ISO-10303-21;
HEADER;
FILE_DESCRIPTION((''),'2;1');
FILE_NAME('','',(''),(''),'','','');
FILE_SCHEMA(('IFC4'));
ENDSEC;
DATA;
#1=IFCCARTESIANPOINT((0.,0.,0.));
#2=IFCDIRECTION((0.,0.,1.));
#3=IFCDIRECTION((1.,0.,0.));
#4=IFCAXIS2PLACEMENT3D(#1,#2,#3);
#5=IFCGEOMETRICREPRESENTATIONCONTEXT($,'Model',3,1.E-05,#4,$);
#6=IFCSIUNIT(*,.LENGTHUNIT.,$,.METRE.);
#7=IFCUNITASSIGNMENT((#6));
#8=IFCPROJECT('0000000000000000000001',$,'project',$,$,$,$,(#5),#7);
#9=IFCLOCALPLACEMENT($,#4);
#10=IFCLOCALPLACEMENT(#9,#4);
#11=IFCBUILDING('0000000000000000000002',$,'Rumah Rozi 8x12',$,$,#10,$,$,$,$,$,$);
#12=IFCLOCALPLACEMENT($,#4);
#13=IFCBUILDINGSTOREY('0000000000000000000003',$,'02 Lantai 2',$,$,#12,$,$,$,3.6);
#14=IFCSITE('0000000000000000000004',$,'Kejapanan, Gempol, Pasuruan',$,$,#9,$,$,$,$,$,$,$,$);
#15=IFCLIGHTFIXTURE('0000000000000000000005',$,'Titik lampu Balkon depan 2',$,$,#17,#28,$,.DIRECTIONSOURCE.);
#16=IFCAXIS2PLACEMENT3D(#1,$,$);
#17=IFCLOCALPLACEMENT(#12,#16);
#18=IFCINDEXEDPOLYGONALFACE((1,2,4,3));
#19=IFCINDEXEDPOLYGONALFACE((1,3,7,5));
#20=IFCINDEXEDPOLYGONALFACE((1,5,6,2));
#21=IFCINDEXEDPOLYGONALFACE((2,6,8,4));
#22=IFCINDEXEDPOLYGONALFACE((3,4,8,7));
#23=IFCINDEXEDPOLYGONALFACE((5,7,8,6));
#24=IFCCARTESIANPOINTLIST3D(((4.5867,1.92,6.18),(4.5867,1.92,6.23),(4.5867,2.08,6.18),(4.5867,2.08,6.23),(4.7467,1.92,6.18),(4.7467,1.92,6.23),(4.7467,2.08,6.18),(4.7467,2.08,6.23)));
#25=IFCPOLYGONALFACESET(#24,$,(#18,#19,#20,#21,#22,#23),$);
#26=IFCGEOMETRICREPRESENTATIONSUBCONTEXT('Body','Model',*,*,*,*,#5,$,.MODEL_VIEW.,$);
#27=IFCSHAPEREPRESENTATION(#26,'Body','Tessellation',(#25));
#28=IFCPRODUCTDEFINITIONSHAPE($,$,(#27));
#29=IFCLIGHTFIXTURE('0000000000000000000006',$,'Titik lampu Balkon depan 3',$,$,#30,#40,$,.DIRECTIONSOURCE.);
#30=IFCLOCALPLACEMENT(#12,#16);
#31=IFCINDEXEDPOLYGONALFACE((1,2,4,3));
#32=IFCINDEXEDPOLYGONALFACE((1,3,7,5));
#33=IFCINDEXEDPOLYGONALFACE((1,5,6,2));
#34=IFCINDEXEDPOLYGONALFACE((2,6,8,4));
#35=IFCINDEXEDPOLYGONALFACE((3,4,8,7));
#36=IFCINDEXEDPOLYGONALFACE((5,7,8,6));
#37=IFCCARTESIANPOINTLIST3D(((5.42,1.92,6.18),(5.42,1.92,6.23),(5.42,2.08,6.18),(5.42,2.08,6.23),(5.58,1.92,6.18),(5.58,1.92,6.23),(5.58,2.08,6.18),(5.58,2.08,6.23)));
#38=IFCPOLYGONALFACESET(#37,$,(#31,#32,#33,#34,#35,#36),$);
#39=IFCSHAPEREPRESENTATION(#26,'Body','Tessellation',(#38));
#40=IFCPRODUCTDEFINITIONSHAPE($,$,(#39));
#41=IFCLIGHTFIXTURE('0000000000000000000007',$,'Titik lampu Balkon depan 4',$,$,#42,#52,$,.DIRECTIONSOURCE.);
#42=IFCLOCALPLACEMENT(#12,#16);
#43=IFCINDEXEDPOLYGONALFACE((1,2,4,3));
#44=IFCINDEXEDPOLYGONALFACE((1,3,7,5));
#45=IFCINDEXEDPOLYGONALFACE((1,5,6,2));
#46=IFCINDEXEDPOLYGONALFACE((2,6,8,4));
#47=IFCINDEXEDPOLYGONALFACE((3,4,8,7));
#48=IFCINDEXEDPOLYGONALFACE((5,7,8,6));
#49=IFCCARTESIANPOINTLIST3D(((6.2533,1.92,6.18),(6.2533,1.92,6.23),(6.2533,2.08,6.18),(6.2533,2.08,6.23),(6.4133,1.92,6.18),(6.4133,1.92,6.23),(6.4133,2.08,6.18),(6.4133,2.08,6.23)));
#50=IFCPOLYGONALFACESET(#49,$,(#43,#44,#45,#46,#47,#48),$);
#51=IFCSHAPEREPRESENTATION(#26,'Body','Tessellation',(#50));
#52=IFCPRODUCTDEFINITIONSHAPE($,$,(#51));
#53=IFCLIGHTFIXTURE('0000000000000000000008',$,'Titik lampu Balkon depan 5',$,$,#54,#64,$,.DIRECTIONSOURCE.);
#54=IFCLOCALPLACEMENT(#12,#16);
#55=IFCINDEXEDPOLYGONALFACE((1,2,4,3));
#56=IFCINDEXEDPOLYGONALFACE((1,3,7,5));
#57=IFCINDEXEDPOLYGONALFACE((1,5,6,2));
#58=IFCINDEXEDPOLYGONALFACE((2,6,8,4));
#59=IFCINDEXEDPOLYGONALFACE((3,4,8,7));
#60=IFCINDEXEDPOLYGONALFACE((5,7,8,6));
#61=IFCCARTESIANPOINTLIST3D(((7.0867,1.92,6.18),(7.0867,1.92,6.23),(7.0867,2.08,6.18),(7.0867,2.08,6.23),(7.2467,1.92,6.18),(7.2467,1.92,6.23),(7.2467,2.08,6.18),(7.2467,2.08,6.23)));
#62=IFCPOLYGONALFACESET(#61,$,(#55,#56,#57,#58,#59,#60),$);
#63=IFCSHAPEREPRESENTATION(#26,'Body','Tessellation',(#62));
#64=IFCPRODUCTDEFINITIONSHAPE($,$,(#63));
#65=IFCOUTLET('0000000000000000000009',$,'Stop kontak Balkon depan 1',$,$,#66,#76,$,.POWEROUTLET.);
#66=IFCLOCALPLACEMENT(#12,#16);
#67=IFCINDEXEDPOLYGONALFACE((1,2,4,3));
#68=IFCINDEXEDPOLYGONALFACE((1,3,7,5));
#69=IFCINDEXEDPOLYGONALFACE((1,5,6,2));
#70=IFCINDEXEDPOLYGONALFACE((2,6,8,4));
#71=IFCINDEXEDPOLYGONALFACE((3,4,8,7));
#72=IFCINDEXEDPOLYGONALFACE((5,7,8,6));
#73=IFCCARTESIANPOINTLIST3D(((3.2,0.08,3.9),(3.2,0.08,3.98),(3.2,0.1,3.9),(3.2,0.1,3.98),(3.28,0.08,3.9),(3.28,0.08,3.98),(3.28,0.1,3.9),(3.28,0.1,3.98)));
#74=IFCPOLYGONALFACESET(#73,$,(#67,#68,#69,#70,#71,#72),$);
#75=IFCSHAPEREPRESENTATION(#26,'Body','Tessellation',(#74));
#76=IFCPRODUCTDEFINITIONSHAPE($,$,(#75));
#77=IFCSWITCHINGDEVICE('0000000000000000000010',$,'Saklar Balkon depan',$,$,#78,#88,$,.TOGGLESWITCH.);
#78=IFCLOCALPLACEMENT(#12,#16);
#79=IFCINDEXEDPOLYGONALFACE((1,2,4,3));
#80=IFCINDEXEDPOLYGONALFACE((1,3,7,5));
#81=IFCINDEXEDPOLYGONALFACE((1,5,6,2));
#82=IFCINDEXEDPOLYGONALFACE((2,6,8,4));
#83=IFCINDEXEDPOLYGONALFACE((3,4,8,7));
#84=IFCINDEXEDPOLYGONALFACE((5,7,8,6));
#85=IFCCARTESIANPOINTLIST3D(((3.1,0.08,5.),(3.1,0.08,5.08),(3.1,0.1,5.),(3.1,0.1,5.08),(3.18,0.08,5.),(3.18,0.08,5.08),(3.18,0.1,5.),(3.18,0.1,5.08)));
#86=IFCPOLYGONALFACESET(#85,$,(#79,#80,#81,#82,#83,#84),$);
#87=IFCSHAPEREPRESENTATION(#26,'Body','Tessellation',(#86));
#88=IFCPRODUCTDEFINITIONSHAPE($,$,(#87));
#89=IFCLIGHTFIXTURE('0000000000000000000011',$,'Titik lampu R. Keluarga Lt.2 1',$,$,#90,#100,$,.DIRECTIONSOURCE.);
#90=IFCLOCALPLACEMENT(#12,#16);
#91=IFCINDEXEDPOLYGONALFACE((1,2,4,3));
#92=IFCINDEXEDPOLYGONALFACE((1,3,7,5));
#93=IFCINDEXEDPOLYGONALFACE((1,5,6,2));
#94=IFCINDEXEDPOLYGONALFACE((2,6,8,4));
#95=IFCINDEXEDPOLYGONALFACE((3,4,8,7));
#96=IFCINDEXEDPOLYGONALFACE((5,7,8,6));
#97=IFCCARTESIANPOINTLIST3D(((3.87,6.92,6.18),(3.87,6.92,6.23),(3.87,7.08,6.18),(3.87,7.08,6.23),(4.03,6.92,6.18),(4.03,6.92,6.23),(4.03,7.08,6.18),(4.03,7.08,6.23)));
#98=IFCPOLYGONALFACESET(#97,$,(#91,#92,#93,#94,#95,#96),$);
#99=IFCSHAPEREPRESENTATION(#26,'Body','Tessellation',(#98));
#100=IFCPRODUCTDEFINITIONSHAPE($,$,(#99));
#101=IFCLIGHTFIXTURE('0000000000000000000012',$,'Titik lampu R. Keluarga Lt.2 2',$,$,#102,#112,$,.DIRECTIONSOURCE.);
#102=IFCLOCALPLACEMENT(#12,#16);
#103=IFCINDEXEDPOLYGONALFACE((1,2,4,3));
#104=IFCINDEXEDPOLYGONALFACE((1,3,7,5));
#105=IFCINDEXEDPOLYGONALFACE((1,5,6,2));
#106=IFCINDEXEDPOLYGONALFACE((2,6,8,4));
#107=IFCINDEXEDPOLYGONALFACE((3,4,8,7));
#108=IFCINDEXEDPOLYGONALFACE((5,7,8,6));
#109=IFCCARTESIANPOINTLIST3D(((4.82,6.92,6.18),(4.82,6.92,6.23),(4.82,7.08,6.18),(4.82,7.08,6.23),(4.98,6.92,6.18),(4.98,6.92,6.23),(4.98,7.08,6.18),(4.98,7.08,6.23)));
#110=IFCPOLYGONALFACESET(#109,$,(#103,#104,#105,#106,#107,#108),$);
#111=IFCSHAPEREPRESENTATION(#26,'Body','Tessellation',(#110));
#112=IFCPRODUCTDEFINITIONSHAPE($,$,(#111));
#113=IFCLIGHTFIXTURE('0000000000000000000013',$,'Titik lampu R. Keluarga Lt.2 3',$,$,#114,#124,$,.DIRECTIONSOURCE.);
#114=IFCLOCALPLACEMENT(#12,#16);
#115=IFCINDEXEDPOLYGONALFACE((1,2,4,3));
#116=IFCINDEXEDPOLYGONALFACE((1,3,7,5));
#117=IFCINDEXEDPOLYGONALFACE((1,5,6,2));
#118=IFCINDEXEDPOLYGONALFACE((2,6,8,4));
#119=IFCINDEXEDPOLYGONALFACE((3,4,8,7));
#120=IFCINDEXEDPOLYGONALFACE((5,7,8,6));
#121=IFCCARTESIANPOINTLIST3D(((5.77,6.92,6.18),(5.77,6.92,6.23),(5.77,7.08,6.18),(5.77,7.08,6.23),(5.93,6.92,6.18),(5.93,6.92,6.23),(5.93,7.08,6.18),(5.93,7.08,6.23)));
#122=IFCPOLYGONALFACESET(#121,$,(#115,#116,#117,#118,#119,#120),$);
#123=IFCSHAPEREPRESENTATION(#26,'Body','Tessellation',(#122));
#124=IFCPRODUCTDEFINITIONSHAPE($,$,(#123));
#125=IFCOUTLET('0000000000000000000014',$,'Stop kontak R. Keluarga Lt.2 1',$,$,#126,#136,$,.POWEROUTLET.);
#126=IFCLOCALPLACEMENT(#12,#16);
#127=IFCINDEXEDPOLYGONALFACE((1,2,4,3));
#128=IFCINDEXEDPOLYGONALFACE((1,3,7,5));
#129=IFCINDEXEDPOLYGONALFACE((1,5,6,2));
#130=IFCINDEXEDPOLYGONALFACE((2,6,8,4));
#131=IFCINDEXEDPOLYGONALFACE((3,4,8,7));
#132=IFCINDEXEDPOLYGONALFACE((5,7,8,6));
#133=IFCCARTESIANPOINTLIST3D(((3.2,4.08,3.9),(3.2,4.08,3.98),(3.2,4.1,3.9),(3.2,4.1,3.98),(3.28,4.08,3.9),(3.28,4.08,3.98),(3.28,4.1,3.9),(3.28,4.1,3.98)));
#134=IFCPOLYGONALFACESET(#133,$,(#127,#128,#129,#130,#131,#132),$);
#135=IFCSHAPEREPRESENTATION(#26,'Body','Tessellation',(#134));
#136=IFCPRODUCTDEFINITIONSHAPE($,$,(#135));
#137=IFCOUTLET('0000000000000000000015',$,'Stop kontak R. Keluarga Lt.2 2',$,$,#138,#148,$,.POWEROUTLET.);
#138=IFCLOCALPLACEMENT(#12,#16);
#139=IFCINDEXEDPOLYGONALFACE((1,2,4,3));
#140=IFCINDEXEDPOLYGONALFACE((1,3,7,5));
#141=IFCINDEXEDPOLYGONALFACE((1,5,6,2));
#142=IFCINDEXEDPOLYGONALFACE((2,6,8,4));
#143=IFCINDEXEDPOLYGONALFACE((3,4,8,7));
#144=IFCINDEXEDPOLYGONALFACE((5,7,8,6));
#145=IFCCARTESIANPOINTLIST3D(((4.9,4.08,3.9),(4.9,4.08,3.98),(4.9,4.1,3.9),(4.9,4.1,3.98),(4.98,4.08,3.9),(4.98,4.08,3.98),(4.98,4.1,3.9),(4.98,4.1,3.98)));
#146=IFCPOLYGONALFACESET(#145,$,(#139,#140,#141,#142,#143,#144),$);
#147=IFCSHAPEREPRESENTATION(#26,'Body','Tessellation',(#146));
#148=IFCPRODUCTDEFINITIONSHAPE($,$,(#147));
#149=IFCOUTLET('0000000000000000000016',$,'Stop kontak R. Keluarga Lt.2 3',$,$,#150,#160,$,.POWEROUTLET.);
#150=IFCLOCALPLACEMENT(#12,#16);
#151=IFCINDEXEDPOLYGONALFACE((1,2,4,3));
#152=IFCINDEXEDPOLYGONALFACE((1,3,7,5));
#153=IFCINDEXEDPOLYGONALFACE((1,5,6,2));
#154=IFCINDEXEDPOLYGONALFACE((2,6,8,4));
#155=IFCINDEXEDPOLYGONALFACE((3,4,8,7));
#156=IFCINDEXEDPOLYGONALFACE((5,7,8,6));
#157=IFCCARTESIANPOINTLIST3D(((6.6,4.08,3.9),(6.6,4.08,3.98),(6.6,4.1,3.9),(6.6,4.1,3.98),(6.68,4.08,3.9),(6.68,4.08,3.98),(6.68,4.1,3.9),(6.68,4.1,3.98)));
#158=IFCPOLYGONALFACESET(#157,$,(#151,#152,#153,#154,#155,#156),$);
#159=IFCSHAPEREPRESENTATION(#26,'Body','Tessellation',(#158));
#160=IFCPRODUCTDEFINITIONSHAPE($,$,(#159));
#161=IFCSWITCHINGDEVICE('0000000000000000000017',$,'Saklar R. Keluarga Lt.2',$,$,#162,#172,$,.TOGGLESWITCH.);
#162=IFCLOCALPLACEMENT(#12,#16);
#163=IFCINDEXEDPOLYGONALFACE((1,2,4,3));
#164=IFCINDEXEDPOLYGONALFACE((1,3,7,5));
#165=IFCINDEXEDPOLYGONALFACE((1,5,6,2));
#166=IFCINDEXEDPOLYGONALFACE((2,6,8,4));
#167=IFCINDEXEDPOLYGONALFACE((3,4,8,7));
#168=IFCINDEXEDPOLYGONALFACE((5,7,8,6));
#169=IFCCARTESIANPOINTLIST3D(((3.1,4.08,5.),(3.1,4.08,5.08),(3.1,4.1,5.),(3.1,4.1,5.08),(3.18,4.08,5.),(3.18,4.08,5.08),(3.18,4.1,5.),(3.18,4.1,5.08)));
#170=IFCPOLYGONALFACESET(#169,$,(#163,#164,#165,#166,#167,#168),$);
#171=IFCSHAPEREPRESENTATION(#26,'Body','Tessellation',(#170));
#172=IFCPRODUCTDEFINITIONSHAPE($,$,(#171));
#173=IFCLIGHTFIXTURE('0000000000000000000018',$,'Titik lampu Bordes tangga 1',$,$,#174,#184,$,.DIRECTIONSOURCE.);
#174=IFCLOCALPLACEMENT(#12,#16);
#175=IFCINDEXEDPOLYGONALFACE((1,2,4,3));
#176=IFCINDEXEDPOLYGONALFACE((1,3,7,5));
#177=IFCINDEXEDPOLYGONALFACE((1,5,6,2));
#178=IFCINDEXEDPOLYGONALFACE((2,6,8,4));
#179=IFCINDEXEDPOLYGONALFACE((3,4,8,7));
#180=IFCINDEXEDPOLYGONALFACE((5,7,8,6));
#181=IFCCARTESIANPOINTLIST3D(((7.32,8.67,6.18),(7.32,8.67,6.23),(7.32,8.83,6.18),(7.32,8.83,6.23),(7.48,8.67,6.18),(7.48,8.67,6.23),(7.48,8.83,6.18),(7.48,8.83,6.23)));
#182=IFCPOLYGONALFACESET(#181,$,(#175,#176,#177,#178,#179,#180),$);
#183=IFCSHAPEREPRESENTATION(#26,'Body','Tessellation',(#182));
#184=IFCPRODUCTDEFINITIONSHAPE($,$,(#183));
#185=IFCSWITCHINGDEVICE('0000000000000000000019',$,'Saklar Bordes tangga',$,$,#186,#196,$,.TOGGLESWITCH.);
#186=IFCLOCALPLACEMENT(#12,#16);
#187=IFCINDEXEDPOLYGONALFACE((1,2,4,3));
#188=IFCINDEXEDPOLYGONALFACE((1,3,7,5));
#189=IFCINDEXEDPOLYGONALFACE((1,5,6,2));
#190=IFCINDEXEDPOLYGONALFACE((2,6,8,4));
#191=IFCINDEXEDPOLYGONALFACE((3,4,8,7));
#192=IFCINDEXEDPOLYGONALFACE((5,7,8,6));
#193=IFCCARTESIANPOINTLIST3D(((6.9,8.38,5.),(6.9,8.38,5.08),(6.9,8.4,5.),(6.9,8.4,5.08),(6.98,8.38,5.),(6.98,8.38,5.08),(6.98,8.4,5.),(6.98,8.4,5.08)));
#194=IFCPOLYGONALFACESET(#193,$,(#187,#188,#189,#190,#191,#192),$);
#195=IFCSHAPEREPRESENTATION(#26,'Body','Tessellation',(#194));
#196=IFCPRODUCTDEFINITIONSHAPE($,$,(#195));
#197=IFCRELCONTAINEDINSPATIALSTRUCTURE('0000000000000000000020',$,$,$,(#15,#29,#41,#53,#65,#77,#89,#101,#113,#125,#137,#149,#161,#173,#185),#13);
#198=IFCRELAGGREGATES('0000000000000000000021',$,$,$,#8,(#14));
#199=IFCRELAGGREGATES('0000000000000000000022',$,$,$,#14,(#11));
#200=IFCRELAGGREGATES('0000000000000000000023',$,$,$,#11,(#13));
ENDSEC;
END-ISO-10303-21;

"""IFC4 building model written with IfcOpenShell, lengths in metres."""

from ifc_helpers import new_model, si_unit, frame, origin_with_axes, place, context, subcontext, project, spatial, line, indexed_curve, outline, extrude, element, save


model = new_model("IFC4")

# Units and contexts
model_context = context("Model", 3, precision=1e-05, world=origin_with_axes())
body_context = subcontext(model_context, "Body", "Model", "MODEL_VIEW")
ifc_project = project(units=[si_unit("LENGTHUNIT", "METRE")], contexts=[model_context])

# Site, building, storey
site_placement = place(None, origin_with_axes())
site = spatial("IfcSite", under=ifc_project, at=site_placement, Name="Kejapanan, Gempol, Pasuruan")
building_placement = place(site_placement, origin_with_axes())
building = spatial("IfcBuilding", under=site, at=building_placement, Name="Rumah Rozi 8x12")
storey_placement = place(None, origin_with_axes())
storey = spatial("IfcBuildingStorey", under=building, at=storey_placement, Name="02 Lantai 2", Elevation=3.6)

# Light fixtures
light_fixture_1_placement = place(storey_placement, origin_with_axes())
element("IfcLightFixture", 1, at=light_fixture_1_placement, inside=storey, Name="Titik lampu Balkon depan 2", PredefinedType="DIRECTIONSOURCE", context=body_context, shape_type="SweptSolid", body=[
    extrude(outline(indexed_curve([(4.5867, 1.92), (4.7467, 1.92), (4.7467, 2.08), (4.5867, 2.08)], segments=[line(1, 2, 3, 4, 1)])), frame((0.0, 0.0, 6.18), z_axis=(0.0, 0.0, 1.0), x_axis=(1.0, 0.0, 0.0)), (0.0, 0.0, 1.0), 0.05),
])
light_fixture_2_placement = place(storey_placement, origin_with_axes())
element("IfcLightFixture", 2, at=light_fixture_2_placement, inside=storey, Name="Titik lampu Balkon depan 3", PredefinedType="DIRECTIONSOURCE", context=body_context, shape_type="SweptSolid", body=[
    extrude(outline(indexed_curve([(5.42, 1.92), (5.58, 1.92), (5.58, 2.08), (5.42, 2.08)], segments=[line(1, 2, 3, 4, 1)])), frame((0.0, 0.0, 6.18), z_axis=(0.0, 0.0, 1.0), x_axis=(1.0, 0.0, 0.0)), (0.0, 0.0, 1.0), 0.05),
])
light_fixture_3_placement = place(storey_placement, origin_with_axes())
element("IfcLightFixture", 3, at=light_fixture_3_placement, inside=storey, Name="Titik lampu Balkon depan 4", PredefinedType="DIRECTIONSOURCE", context=body_context, shape_type="SweptSolid", body=[
    extrude(outline(indexed_curve([(6.2533, 1.92), (6.4133, 1.92), (6.4133, 2.08), (6.2533, 2.08)], segments=[line(1, 2, 3, 4, 1)])), frame((0.0, 0.0, 6.18), z_axis=(0.0, 0.0, 1.0), x_axis=(1.0, 0.0, 0.0)), (0.0, 0.0, 1.0), 0.05),
])
light_fixture_4_placement = place(storey_placement, origin_with_axes())
element("IfcLightFixture", 4, at=light_fixture_4_placement, inside=storey, Name="Titik lampu Balkon depan 5", PredefinedType="DIRECTIONSOURCE", context=body_context, shape_type="SweptSolid", body=[
    extrude(outline(indexed_curve([(7.0867, 1.92), (7.2467, 1.92), (7.2467, 2.08), (7.0867, 2.08)], segments=[line(1, 2, 3, 4, 1)])), frame((0.0, 0.0, 6.18), z_axis=(0.0, 0.0, 1.0), x_axis=(1.0, 0.0, 0.0)), (0.0, 0.0, 1.0), 0.05),
])

# Outlet
outlet_1_placement = place(storey_placement, origin_with_axes())
element("IfcOutlet", 5, at=outlet_1_placement, inside=storey, Name="Stop kontak Balkon depan 1", PredefinedType="POWEROUTLET", context=body_context, shape_type="SweptSolid", body=[
    extrude(outline(indexed_curve([(3.2, 0.08), (3.28, 0.08), (3.28, 0.1), (3.2, 0.1)], segments=[line(1, 2, 3, 4, 1)])), frame((0.0, 0.0, 3.9), z_axis=(0.0, 0.0, 1.0), x_axis=(1.0, 0.0, 0.0)), (0.0, 0.0, 1.0), 0.08),
])

# Switching device
switching_device_1_placement = place(storey_placement, origin_with_axes())
element("IfcSwitchingDevice", 6, at=switching_device_1_placement, inside=storey, Name="Saklar Balkon depan", PredefinedType="TOGGLESWITCH", context=body_context, shape_type="SweptSolid", body=[
    extrude(outline(indexed_curve([(3.1, 0.08), (3.18, 0.08), (3.18, 0.1), (3.1, 0.1)], segments=[line(1, 2, 3, 4, 1)])), frame((0.0, 0.0, 5.0), z_axis=(0.0, 0.0, 1.0), x_axis=(1.0, 0.0, 0.0)), (0.0, 0.0, 1.0), 0.08),
])

# Light fixtures
light_fixture_5_placement = place(storey_placement, origin_with_axes())
element("IfcLightFixture", 7, at=light_fixture_5_placement, inside=storey, Name="Titik lampu R. Keluarga Lt.2 1", PredefinedType="DIRECTIONSOURCE", context=body_context, shape_type="SweptSolid", body=[
    extrude(outline(indexed_curve([(3.87, 6.92), (4.03, 6.92), (4.03, 7.08), (3.87, 7.08)], segments=[line(1, 2, 3, 4, 1)])), frame((0.0, 0.0, 6.18), z_axis=(0.0, 0.0, 1.0), x_axis=(1.0, 0.0, 0.0)), (0.0, 0.0, 1.0), 0.05),
])
light_fixture_6_placement = place(storey_placement, origin_with_axes())
element("IfcLightFixture", 8, at=light_fixture_6_placement, inside=storey, Name="Titik lampu R. Keluarga Lt.2 2", PredefinedType="DIRECTIONSOURCE", context=body_context, shape_type="SweptSolid", body=[
    extrude(outline(indexed_curve([(4.82, 6.92), (4.98, 6.92), (4.98, 7.08), (4.82, 7.08)], segments=[line(1, 2, 3, 4, 1)])), frame((0.0, 0.0, 6.18), z_axis=(0.0, 0.0, 1.0), x_axis=(1.0, 0.0, 0.0)), (0.0, 0.0, 1.0), 0.05),
])
light_fixture_7_placement = place(storey_placement, origin_with_axes())
element("IfcLightFixture", 9, at=light_fixture_7_placement, inside=storey, Name="Titik lampu R. Keluarga Lt.2 3", PredefinedType="DIRECTIONSOURCE", context=body_context, shape_type="SweptSolid", body=[
    extrude(outline(indexed_curve([(5.77, 6.92), (5.93, 6.92), (5.93, 7.08), (5.77, 7.08)], segments=[line(1, 2, 3, 4, 1)])), frame((0.0, 0.0, 6.18), z_axis=(0.0, 0.0, 1.0), x_axis=(1.0, 0.0, 0.0)), (0.0, 0.0, 1.0), 0.05),
])

# Outlets
outlet_2_placement = place(storey_placement, origin_with_axes())
element("IfcOutlet", 10, at=outlet_2_placement, inside=storey, Name="Stop kontak R. Keluarga Lt.2 1", PredefinedType="POWEROUTLET", context=body_context, shape_type="SweptSolid", body=[
    extrude(outline(indexed_curve([(3.2, 4.08), (3.28, 4.08), (3.28, 4.1), (3.2, 4.1)], segments=[line(1, 2, 3, 4, 1)])), frame((0.0, 0.0, 3.9), z_axis=(0.0, 0.0, 1.0), x_axis=(1.0, 0.0, 0.0)), (0.0, 0.0, 1.0), 0.08),
])
outlet_3_placement = place(storey_placement, origin_with_axes())
element("IfcOutlet", 11, at=outlet_3_placement, inside=storey, Name="Stop kontak R. Keluarga Lt.2 2", PredefinedType="POWEROUTLET", context=body_context, shape_type="SweptSolid", body=[
    extrude(outline(indexed_curve([(4.9, 4.08), (4.98, 4.08), (4.98, 4.1), (4.9, 4.1)], segments=[line(1, 2, 3, 4, 1)])), frame((0.0, 0.0, 3.9), z_axis=(0.0, 0.0, 1.0), x_axis=(1.0, 0.0, 0.0)), (0.0, 0.0, 1.0), 0.08),
])
outlet_4_placement = place(storey_placement, origin_with_axes())
element("IfcOutlet", 12, at=outlet_4_placement, inside=storey, Name="Stop kontak R. Keluarga Lt.2 3", PredefinedType="POWEROUTLET", context=body_context, shape_type="SweptSolid", body=[
    extrude(outline(indexed_curve([(6.6, 4.08), (6.68, 4.08), (6.68, 4.1), (6.6, 4.1)], segments=[line(1, 2, 3, 4, 1)])), frame((0.0, 0.0, 3.9), z_axis=(0.0, 0.0, 1.0), x_axis=(1.0, 0.0, 0.0)), (0.0, 0.0, 1.0), 0.08),
])

# Switching device
switching_device_2_placement = place(storey_placement, origin_with_axes())
element("IfcSwitchingDevice", 13, at=switching_device_2_placement, inside=storey, Name="Saklar R. Keluarga Lt.2", PredefinedType="TOGGLESWITCH", context=body_context, shape_type="SweptSolid", body=[
    extrude(outline(indexed_curve([(3.1, 4.08), (3.18, 4.08), (3.18, 4.1), (3.1, 4.1)], segments=[line(1, 2, 3, 4, 1)])), frame((0.0, 0.0, 5.0), z_axis=(0.0, 0.0, 1.0), x_axis=(1.0, 0.0, 0.0)), (0.0, 0.0, 1.0), 0.08),
])

# Light fixture
light_fixture_8_placement = place(storey_placement, origin_with_axes())
element("IfcLightFixture", 14, at=light_fixture_8_placement, inside=storey, Name="Titik lampu Bordes tangga 1", PredefinedType="DIRECTIONSOURCE", context=body_context, shape_type="SweptSolid", body=[
    extrude(outline(indexed_curve([(7.32, 8.67), (7.48, 8.67), (7.48, 8.83), (7.32, 8.83)], segments=[line(1, 2, 3, 4, 1)])), frame((0.0, 0.0, 6.18), z_axis=(0.0, 0.0, 1.0), x_axis=(1.0, 0.0, 0.0)), (0.0, 0.0, 1.0), 0.05),
])

# Switching device
switching_device_3_placement = place(storey_placement, origin_with_axes())
element("IfcSwitchingDevice", 15, at=switching_device_3_placement, inside=storey, Name="Saklar Bordes tangga", PredefinedType="TOGGLESWITCH", context=body_context, shape_type="SweptSolid", body=[
    extrude(outline(indexed_curve([(6.9, 8.38), (6.98, 8.38), (6.98, 8.4), (6.9, 8.4)], segments=[line(1, 2, 3, 4, 1)])), frame((0.0, 0.0, 5.0), z_axis=(0.0, 0.0, 1.0), x_axis=(1.0, 0.0, 0.0)), (0.0, 0.0, 1.0), 0.08),
])

save(model, "model.ifc")
